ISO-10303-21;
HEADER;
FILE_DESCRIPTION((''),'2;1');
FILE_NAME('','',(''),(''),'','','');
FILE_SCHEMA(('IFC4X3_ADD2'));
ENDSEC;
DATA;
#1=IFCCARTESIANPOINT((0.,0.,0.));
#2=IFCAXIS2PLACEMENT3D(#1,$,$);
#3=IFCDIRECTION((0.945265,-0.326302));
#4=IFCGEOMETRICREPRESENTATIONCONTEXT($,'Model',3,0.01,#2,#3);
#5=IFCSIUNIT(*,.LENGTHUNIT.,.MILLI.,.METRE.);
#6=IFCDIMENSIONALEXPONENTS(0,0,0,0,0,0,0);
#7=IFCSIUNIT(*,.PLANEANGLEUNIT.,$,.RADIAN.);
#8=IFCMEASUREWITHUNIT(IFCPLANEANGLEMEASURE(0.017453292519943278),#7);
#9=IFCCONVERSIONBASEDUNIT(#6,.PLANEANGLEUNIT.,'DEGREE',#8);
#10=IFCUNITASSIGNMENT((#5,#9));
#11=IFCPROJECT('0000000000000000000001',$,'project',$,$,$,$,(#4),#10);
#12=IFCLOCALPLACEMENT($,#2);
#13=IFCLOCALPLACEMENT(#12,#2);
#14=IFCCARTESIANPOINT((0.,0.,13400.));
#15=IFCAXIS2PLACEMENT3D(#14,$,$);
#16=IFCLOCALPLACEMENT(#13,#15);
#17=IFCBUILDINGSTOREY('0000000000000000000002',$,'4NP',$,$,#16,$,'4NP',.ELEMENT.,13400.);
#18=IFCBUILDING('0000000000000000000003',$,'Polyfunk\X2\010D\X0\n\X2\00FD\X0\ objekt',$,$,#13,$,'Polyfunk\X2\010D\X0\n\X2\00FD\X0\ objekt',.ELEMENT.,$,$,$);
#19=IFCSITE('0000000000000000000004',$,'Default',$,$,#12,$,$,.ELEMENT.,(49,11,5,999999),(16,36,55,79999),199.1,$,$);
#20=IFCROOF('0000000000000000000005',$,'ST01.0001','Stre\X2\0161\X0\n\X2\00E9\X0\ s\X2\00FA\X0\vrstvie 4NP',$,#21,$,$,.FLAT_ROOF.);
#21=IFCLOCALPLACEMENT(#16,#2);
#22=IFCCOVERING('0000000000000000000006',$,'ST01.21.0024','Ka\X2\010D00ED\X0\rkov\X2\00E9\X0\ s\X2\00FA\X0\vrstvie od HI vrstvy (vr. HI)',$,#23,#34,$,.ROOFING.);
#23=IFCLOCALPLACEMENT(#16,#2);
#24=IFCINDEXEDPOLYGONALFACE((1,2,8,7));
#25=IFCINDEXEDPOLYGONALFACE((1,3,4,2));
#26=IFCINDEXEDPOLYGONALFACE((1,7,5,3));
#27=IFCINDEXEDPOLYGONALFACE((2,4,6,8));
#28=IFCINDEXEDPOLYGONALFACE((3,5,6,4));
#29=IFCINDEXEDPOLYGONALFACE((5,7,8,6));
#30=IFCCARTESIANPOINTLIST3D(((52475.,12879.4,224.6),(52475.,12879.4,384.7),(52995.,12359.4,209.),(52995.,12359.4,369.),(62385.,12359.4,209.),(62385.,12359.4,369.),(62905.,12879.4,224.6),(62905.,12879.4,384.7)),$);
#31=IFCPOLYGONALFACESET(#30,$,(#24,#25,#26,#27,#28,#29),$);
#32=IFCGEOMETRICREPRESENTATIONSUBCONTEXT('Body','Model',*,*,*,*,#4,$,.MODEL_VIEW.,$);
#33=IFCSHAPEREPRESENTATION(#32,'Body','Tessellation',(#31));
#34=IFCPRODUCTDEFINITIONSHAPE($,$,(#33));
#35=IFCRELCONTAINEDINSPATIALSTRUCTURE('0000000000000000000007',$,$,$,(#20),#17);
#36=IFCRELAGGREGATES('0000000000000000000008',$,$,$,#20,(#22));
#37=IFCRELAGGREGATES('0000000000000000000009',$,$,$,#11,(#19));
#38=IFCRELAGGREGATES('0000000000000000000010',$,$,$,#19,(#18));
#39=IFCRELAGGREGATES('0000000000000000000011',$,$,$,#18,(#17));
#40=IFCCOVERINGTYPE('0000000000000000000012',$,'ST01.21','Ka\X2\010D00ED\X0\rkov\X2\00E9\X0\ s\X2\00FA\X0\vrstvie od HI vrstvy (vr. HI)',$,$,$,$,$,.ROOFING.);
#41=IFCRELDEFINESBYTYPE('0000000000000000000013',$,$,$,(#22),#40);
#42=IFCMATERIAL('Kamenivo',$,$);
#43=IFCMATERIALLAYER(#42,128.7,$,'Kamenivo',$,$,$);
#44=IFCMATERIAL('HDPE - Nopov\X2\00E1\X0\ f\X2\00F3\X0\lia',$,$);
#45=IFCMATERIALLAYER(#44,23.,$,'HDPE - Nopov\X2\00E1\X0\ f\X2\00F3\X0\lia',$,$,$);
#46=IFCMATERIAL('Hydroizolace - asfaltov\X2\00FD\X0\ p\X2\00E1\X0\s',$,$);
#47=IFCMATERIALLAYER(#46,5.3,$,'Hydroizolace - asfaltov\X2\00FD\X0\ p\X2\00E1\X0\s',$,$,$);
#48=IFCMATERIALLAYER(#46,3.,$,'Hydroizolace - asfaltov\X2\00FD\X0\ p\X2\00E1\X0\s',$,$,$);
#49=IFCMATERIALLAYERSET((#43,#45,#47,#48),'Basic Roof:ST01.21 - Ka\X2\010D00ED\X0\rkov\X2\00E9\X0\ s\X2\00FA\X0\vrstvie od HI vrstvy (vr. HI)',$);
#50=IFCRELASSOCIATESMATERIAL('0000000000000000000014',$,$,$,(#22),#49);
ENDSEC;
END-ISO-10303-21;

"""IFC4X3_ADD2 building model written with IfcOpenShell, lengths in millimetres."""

from ifc_helpers import new_model, entity, si_unit, converted_unit, direction, frame, origin, place, context, subcontext, project, spatial, polyline, outline, extrude, material, layer, layer_set, type_object, element, aggregate, save


model = new_model("IFC4X3_ADD2")

# Units and contexts
model_context = context("Model", 3, precision=0.01, world=origin(), true_north=direction((0.945265, -0.326302)))
body_context = subcontext(model_context, "Body", "Model", "MODEL_VIEW")
ifc_project = project(units=[si_unit("LENGTHUNIT", "METRE", prefix="MILLI"), converted_unit("PLANEANGLEUNIT", "DEGREE", entity("IfcPlaneAngleMeasure", 0.017453292519943278), si_unit("PLANEANGLEUNIT", "RADIAN"), dimensions=[0, 0, 0, 0, 0, 0, 0])], contexts=[model_context])

# Site, building, storey
site_placement = place(None, origin())
site = spatial("IfcSite", under=ifc_project, at=site_placement, Name="Default", CompositionType="ELEMENT", RefLatitude=(49, 11, 5, 999999), RefLongitude=(16, 36, 55, 79999), RefElevation=199.1)
building_placement = place(site_placement, origin())
building = spatial("IfcBuilding", under=site, at=building_placement, Name="Polyfunkčný objekt", LongName="Polyfunkčný objekt", CompositionType="ELEMENT")
storey_placement = place(building_placement, frame((0.0, 0.0, 13400.0)))
storey = spatial("IfcBuildingStorey", under=building, at=storey_placement, Name="4NP", LongName="4NP", CompositionType="ELEMENT", Elevation=13400.0)

# Roof, covering
roof = element("IfcRoof", 1, inside=storey, Name="ST01.0001", Description="Strešné súvrstvie 4NP", PredefinedType="FLAT_ROOF")
ifc_material_1 = material(Name="HDPE - Nopová fólia")
ifc_material_2 = material(Name="Hydroizolace - asfaltový pás")
ifc_material_3 = material(Name="Kamenivo")
ifc_layer_1 = layer(ifc_material_3, 128.7, Name="Kamenivo")
ifc_layer_2 = layer(ifc_material_1, 23.0, Name="HDPE - Nopová fólia")
ifc_layer_3 = layer(ifc_material_2, 5.3, Name="Hydroizolace - asfaltový pás")
ifc_layer_4 = layer(ifc_material_2, 3.0, Name="Hydroizolace - asfaltový pás")
ifc_layer_set_1 = layer_set([ifc_layer_1, ifc_layer_2, ifc_layer_3, ifc_layer_4], Name="Basic Roof:ST01.21 - Kačírkové súvrstvie od HI vrstvy (vr. HI)")
covering_type_1 = type_object("IfcCoveringType", Name="ST01.21", Description="Kačírkové súvrstvie od HI vrstvy (vr. HI)", PredefinedType="ROOFING")
placement_1 = place(storey_placement, frame((52475.0, 12359.4, 209.0)))
covering_1_placement = place(placement_1, origin())
covering_1 = element("IfcCovering", 2, at=covering_1_placement, type_object=covering_type_1, material=ifc_layer_set_1, Name="ST01.21.0024", Description="Kačírkové súvrstvie od HI vrstvy (vr. HI)", PredefinedType="ROOFING", context=body_context, shape_type="SweptSolid", body=[
    extrude(outline(polyline([(4695.0, -260.1), (5215.0, 260.1), (-5215.0, 260.1), (-4695.0, -260.1), (4695.0, -260.1)])), frame((5215.0, 260.0, 7.8), z_axis=(0.0, -0.030015, 0.999549), x_axis=(1.0, 0.0, 0.0)), (0.0, 0.030015, 0.999549), 160.1),
])
aggregate(roof, [covering_1])

save(model, "model.ifc")
